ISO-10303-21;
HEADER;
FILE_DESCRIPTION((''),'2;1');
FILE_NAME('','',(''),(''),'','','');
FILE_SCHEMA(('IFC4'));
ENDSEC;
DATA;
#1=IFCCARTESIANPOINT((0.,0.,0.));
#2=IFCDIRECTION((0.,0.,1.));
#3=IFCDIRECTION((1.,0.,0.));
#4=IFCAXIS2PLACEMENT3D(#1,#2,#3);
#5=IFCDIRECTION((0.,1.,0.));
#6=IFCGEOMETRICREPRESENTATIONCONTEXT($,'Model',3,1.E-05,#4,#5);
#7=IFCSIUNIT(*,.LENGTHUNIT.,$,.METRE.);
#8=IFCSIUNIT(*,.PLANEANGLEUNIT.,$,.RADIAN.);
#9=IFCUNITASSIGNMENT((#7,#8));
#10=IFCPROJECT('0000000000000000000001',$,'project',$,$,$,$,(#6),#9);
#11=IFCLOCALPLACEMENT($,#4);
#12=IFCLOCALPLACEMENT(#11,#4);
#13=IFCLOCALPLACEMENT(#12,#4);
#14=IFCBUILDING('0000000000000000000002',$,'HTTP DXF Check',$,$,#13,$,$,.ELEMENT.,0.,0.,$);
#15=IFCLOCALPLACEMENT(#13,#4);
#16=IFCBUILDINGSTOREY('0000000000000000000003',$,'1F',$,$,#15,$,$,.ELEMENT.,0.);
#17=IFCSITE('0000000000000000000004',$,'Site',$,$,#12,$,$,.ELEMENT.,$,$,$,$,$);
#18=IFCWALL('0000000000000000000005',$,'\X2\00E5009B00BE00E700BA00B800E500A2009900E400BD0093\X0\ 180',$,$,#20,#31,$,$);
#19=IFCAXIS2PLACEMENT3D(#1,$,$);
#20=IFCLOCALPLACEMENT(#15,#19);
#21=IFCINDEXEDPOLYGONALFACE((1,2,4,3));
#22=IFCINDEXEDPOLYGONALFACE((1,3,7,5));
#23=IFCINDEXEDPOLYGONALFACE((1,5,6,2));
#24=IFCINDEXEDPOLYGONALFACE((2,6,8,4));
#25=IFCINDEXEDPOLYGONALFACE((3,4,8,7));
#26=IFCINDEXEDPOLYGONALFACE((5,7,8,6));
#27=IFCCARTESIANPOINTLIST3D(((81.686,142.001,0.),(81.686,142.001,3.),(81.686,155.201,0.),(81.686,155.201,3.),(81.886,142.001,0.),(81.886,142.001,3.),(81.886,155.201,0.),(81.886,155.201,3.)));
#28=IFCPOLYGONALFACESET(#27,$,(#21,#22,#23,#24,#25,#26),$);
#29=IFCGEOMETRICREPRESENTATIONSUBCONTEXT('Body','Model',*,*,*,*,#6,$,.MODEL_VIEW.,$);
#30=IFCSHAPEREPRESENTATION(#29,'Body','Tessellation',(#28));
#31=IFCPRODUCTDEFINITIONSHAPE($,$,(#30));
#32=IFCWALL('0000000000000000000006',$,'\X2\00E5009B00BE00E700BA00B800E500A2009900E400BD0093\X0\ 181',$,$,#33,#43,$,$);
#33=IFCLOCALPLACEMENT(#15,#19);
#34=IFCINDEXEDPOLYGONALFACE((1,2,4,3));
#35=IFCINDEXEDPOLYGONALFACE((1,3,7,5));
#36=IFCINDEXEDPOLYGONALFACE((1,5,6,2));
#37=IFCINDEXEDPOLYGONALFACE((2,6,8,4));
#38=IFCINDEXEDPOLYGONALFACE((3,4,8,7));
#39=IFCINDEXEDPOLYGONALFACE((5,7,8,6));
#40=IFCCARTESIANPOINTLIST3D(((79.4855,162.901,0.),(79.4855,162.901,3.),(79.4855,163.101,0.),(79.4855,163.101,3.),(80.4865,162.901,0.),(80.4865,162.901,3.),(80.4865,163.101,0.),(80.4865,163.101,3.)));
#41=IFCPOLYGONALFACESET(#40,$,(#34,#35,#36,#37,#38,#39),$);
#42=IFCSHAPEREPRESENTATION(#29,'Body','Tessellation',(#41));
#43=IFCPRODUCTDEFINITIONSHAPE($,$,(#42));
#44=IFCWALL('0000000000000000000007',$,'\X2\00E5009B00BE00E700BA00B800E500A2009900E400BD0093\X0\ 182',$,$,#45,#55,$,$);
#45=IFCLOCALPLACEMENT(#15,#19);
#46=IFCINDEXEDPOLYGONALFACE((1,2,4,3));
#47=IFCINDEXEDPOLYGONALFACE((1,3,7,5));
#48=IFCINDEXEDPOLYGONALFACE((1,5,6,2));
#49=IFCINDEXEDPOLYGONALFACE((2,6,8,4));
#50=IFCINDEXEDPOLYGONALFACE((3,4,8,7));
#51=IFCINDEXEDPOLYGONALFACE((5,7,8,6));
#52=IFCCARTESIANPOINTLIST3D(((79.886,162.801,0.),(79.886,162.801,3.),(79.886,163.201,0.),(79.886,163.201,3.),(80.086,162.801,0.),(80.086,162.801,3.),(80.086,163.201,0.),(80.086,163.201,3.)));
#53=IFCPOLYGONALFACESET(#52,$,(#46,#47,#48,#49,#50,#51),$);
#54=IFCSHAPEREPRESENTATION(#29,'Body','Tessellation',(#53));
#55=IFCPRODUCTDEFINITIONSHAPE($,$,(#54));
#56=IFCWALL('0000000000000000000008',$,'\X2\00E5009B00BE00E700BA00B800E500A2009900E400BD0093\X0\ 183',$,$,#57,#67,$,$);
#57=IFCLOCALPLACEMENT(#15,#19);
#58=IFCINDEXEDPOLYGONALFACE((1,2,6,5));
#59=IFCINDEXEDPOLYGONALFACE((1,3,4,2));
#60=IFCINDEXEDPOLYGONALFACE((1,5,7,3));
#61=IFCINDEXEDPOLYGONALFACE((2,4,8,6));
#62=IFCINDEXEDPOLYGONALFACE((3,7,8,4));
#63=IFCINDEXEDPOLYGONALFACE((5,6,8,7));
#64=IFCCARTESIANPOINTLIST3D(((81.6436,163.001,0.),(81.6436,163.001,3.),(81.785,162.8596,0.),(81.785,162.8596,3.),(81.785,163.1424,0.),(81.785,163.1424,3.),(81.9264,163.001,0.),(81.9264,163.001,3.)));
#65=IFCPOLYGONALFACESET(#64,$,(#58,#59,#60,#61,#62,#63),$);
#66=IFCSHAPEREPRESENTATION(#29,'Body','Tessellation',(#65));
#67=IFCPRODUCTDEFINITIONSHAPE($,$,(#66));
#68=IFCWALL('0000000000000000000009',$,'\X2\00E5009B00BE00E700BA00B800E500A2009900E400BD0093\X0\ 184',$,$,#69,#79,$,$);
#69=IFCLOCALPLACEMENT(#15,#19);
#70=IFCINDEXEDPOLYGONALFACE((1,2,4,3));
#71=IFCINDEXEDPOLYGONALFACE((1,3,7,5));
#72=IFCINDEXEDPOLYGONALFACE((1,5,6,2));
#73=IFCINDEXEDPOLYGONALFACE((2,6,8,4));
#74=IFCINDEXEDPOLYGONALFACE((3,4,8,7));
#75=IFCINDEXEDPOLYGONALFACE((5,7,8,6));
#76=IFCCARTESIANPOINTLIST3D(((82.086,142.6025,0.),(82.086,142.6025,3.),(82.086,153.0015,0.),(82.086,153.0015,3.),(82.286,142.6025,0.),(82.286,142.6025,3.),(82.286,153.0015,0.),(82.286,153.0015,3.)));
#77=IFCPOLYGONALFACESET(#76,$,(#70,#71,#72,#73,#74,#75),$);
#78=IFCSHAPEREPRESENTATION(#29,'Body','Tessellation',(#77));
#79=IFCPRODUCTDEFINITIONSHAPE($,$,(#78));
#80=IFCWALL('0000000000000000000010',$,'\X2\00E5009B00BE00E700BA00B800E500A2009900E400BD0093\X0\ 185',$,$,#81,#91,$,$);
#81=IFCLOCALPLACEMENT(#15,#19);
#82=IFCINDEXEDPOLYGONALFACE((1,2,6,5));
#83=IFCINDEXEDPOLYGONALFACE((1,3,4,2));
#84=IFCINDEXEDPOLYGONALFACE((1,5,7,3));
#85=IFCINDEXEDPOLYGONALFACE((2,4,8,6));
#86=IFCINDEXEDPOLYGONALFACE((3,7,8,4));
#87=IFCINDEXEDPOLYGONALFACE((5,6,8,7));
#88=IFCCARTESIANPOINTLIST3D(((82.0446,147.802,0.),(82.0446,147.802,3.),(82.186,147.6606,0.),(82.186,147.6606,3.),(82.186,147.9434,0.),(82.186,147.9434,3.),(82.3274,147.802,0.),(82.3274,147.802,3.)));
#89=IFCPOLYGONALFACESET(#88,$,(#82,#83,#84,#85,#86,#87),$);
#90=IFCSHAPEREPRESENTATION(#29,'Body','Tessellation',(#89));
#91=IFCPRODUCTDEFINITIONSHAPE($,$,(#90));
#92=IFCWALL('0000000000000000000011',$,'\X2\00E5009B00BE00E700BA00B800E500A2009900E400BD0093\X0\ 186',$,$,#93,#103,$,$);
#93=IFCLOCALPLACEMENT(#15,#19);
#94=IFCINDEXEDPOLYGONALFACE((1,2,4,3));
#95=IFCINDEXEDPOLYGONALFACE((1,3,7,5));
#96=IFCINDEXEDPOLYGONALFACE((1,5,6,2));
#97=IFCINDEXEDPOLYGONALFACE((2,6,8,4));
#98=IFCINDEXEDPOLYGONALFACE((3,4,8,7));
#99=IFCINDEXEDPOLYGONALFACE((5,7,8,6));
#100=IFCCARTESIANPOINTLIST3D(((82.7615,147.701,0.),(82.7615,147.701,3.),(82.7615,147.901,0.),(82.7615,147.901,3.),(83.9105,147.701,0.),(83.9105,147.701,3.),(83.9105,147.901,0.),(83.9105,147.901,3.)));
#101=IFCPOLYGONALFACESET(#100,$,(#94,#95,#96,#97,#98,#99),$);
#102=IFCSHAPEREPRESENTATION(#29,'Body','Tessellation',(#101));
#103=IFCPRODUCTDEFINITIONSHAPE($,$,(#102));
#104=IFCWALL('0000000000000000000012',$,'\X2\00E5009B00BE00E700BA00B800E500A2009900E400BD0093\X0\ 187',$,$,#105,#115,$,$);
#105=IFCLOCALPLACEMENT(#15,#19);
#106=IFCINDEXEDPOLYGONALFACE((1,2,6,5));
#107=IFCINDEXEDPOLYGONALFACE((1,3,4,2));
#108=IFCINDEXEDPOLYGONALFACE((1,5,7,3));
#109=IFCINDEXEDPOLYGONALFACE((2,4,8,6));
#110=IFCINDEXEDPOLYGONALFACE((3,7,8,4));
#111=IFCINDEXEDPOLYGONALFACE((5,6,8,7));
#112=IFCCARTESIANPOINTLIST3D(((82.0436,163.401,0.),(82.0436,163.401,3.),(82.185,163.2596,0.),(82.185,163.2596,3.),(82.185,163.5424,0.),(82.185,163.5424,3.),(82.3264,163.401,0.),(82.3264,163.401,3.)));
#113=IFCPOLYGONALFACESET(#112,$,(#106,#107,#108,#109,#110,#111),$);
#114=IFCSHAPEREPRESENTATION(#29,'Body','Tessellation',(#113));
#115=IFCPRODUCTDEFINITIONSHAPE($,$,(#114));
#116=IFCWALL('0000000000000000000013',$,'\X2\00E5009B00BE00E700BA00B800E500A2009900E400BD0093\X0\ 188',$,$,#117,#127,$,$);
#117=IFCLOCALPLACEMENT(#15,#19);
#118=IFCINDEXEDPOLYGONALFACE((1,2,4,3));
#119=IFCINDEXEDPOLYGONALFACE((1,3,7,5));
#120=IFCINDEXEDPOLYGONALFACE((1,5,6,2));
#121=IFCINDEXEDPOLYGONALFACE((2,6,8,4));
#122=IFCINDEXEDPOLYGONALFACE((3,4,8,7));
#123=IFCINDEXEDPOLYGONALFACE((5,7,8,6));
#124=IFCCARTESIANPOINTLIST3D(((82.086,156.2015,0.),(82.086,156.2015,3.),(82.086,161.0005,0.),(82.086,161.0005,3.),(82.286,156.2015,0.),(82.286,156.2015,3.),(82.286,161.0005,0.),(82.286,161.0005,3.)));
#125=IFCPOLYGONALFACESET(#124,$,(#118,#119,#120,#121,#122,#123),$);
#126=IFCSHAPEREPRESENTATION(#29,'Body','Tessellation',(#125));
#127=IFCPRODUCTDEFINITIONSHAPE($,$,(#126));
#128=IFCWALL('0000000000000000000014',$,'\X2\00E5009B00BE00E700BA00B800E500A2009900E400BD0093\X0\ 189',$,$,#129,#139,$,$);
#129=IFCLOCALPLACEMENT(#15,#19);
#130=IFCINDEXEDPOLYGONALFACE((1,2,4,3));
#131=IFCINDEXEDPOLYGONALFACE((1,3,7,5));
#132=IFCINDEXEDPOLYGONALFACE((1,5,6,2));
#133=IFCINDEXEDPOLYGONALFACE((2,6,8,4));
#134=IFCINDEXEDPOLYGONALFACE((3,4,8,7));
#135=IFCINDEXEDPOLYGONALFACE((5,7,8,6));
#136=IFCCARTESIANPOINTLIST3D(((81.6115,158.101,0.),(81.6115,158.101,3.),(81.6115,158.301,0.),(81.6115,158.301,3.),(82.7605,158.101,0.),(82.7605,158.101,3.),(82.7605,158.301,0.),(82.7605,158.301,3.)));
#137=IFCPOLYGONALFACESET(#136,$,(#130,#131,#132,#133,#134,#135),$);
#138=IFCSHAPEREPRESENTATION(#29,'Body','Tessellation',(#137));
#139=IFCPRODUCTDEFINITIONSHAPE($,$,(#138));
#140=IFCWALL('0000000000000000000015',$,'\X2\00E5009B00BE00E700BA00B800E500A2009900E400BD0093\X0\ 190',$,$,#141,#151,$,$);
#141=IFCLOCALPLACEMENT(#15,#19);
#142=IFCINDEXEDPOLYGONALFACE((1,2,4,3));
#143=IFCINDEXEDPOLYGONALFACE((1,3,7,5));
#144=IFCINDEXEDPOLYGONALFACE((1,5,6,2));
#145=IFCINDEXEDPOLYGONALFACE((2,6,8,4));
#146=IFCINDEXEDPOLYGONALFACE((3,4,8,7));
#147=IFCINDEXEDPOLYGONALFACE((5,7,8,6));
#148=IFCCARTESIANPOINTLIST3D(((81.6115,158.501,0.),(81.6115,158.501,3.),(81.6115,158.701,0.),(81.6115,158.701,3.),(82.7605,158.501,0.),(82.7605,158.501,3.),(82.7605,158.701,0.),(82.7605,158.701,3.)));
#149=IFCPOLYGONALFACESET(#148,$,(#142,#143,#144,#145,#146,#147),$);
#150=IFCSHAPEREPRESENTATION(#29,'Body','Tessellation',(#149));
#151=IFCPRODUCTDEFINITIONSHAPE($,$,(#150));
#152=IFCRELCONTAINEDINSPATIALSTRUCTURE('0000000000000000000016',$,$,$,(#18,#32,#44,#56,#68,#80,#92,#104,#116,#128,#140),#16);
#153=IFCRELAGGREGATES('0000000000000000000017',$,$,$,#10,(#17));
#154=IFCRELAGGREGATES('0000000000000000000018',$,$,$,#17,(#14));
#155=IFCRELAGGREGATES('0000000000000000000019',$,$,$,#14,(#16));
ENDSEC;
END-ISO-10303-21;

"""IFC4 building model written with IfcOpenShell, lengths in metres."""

from ifc_helpers import new_model, si_unit, direction, frame, frame_2d, origin_with_axes, place, context, subcontext, project, spatial, rectangle, extrude, element, save


model = new_model("IFC4")

# Units and contexts
model_context = context("Model", 3, precision=1e-05, world=origin_with_axes(), true_north=direction((0.0, 1.0, 0.0)))
body_context = subcontext(model_context, "Body", "Model", "MODEL_VIEW")
ifc_project = project(units=[si_unit("LENGTHUNIT", "METRE"), si_unit("PLANEANGLEUNIT", "RADIAN")], contexts=[model_context])

# Site, building, storey
placement = place(None, origin_with_axes())
site_placement = place(placement, origin_with_axes())
site = spatial("IfcSite", under=ifc_project, at=site_placement, Name="Site", CompositionType="ELEMENT")
building_placement = place(site_placement, origin_with_axes())
building = spatial("IfcBuilding", under=site, at=building_placement, Name="HTTP DXF Check", CompositionType="ELEMENT", ElevationOfRefHeight=0.0, ElevationOfTerrain=0.0)
storey_placement = place(building_placement, origin_with_axes())
storey = spatial("IfcBuildingStorey", under=building, at=storey_placement, Name="1F", CompositionType="ELEMENT", Elevation=0.0)

# Walls
wall_1_placement = place(storey_placement, frame((81.786, 148.601, 0.0), z_axis=(0.0, 0.0, 1.0), x_axis=(0.0, 1.0, 0.0)))
element("IfcWall", 1, at=wall_1_placement, inside=storey, Name="å\u009b¾çº¸å¢\u0099ä½\u0093 180", context=body_context, shape_type="SweptSolid", body=[
    extrude(rectangle(XDim=13.2, YDim=0.2, at=frame_2d((0.0, 0.0), x_axis=(1.0, 0.0, 0.0))), frame((0.0, 0.0, 0.0), z_axis=(0.0, 0.0, 1.0)), (0.0, 0.0, 1.0), 3.0),
])
wall_2_placement = place(storey_placement, frame((79.986, 163.001, 0.0), z_axis=(0.0, 0.0, 1.0), x_axis=(1.0, 0.0, 0.0)))
element("IfcWall", 2, at=wall_2_placement, inside=storey, Name="å\u009b¾çº¸å¢\u0099ä½\u0093 181", context=body_context, shape_type="SweptSolid", body=[
    extrude(rectangle(XDim=1.001, YDim=0.2, at=frame_2d((0.0, 0.0), x_axis=(1.0, 0.0, 0.0))), frame((0.0, 0.0, 0.0), z_axis=(0.0, 0.0, 1.0)), (0.0, 0.0, 1.0), 3.0),
])
wall_3_placement = place(storey_placement, frame((79.986, 163.001, 0.0), z_axis=(0.0, 0.0, 1.0), x_axis=(0.0, 1.0, 0.0)))
element("IfcWall", 3, at=wall_3_placement, inside=storey, Name="å\u009b¾çº¸å¢\u0099ä½\u0093 182", context=body_context, shape_type="SweptSolid", body=[
    extrude(rectangle(XDim=0.4, YDim=0.2, at=frame_2d((0.0, 0.0), x_axis=(1.0, 0.0, 0.0))), frame((0.0, 0.0, 0.0), z_axis=(0.0, 0.0, 1.0)), (0.0, 0.0, 1.0), 3.0),
])
wall_4_placement = place(storey_placement, frame((81.785, 163.001, 0.0), z_axis=(0.0, 0.0, 1.0), x_axis=(0.707107, -0.707107, 0.0)))
element("IfcWall", 4, at=wall_4_placement, inside=storey, Name="å\u009b¾çº¸å¢\u0099ä½\u0093 183", context=body_context, shape_type="SweptSolid", body=[
    extrude(rectangle(XDim=0.2, YDim=0.2, at=frame_2d((0.0, 0.0), x_axis=(1.0, 0.0, 0.0))), frame((0.0, 0.0, 0.0), z_axis=(0.0, 0.0, 1.0)), (0.0, 0.0, 1.0), 3.0),
])
wall_5_placement = place(storey_placement, frame((82.186, 147.802, 0.0), z_axis=(0.0, 0.0, 1.0), x_axis=(0.0, 1.0, 0.0)))
element("IfcWall", 5, at=wall_5_placement, inside=storey, Name="å\u009b¾çº¸å¢\u0099ä½\u0093 184", context=body_context, shape_type="SweptSolid", body=[
    extrude(rectangle(XDim=10.399, YDim=0.2, at=frame_2d((0.0, 0.0), x_axis=(1.0, 0.0, 0.0))), frame((0.0, 0.0, 0.0), z_axis=(0.0, 0.0, 1.0)), (0.0, 0.0, 1.0), 3.0),
])
wall_6_placement = place(storey_placement, frame((82.186, 147.802, 0.0), z_axis=(0.0, 0.0, 1.0), x_axis=(0.707107, -0.707107, 0.0)))
element("IfcWall", 6, at=wall_6_placement, inside=storey, Name="å\u009b¾çº¸å¢\u0099ä½\u0093 185", context=body_context, shape_type="SweptSolid", body=[
    extrude(rectangle(XDim=0.2, YDim=0.2, at=frame_2d((0.0, 0.0), x_axis=(1.0, 0.0, 0.0))), frame((0.0, 0.0, 0.0), z_axis=(0.0, 0.0, 1.0)), (0.0, 0.0, 1.0), 3.0),
])
wall_7_placement = place(storey_placement, frame((83.336, 147.801, 0.0), z_axis=(0.0, 0.0, 1.0), x_axis=(-1.0, 0.0, 0.0)))
element("IfcWall", 7, at=wall_7_placement, inside=storey, Name="å\u009b¾çº¸å¢\u0099ä½\u0093 186", context=body_context, shape_type="SweptSolid", body=[
    extrude(rectangle(XDim=1.149, YDim=0.2, at=frame_2d((0.0, 0.0), x_axis=(1.0, 0.0, 0.0))), frame((0.0, 0.0, 0.0), z_axis=(0.0, 0.0, 1.0)), (0.0, 0.0, 1.0), 3.0),
])
wall_8_placement = place(storey_placement, frame((82.185, 163.401, 0.0), z_axis=(0.0, 0.0, 1.0), x_axis=(0.707107, -0.707107, 0.0)))
element("IfcWall", 8, at=wall_8_placement, inside=storey, Name="å\u009b¾çº¸å¢\u0099ä½\u0093 187", context=body_context, shape_type="SweptSolid", body=[
    extrude(rectangle(XDim=0.2, YDim=0.2, at=frame_2d((0.0, 0.0), x_axis=(1.0, 0.0, 0.0))), frame((0.0, 0.0, 0.0), z_axis=(0.0, 0.0, 1.0)), (0.0, 0.0, 1.0), 3.0),
])
wall_9_placement = place(storey_placement, frame((82.186, 158.601, 0.0), z_axis=(0.0, 0.0, 1.0), x_axis=(0.0, 1.0, 0.0)))
element("IfcWall", 9, at=wall_9_placement, inside=storey, Name="å\u009b¾çº¸å¢\u0099ä½\u0093 188", context=body_context, shape_type="SweptSolid", body=[
    extrude(rectangle(XDim=4.799, YDim=0.2, at=frame_2d((0.0, 0.0), x_axis=(1.0, 0.0, 0.0))), frame((0.0, 0.0, 0.0), z_axis=(0.0, 0.0, 1.0)), (0.0, 0.0, 1.0), 3.0),
])
for number, where, z_axis, x_axis, name in (
    (10, (82.186, 158.201, 0.0), (0.0, 0.0, 1.0), (1.0, 0.0, 0.0), "å\u009b¾çº¸å¢\u0099ä½\u0093 189"),
    (11, (82.186, 158.601, 0.0), (0.0, 0.0, 1.0), (1.0, 0.0, 0.0), "å\u009b¾çº¸å¢\u0099ä½\u0093 190"),
):
    element("IfcWall", number, at=place(storey_placement, frame(where, z_axis=z_axis, x_axis=x_axis)), inside=storey, Name=name, context=body_context, shape_type="SweptSolid", body=[
        extrude(rectangle(XDim=1.149, YDim=0.2, at=frame_2d((0.0, 0.0), x_axis=(1.0, 0.0, 0.0))), frame((0.0, 0.0, 0.0), z_axis=(0.0, 0.0, 1.0)), (0.0, 0.0, 1.0), 3.0),
    ])

save(model, "model.ifc")
